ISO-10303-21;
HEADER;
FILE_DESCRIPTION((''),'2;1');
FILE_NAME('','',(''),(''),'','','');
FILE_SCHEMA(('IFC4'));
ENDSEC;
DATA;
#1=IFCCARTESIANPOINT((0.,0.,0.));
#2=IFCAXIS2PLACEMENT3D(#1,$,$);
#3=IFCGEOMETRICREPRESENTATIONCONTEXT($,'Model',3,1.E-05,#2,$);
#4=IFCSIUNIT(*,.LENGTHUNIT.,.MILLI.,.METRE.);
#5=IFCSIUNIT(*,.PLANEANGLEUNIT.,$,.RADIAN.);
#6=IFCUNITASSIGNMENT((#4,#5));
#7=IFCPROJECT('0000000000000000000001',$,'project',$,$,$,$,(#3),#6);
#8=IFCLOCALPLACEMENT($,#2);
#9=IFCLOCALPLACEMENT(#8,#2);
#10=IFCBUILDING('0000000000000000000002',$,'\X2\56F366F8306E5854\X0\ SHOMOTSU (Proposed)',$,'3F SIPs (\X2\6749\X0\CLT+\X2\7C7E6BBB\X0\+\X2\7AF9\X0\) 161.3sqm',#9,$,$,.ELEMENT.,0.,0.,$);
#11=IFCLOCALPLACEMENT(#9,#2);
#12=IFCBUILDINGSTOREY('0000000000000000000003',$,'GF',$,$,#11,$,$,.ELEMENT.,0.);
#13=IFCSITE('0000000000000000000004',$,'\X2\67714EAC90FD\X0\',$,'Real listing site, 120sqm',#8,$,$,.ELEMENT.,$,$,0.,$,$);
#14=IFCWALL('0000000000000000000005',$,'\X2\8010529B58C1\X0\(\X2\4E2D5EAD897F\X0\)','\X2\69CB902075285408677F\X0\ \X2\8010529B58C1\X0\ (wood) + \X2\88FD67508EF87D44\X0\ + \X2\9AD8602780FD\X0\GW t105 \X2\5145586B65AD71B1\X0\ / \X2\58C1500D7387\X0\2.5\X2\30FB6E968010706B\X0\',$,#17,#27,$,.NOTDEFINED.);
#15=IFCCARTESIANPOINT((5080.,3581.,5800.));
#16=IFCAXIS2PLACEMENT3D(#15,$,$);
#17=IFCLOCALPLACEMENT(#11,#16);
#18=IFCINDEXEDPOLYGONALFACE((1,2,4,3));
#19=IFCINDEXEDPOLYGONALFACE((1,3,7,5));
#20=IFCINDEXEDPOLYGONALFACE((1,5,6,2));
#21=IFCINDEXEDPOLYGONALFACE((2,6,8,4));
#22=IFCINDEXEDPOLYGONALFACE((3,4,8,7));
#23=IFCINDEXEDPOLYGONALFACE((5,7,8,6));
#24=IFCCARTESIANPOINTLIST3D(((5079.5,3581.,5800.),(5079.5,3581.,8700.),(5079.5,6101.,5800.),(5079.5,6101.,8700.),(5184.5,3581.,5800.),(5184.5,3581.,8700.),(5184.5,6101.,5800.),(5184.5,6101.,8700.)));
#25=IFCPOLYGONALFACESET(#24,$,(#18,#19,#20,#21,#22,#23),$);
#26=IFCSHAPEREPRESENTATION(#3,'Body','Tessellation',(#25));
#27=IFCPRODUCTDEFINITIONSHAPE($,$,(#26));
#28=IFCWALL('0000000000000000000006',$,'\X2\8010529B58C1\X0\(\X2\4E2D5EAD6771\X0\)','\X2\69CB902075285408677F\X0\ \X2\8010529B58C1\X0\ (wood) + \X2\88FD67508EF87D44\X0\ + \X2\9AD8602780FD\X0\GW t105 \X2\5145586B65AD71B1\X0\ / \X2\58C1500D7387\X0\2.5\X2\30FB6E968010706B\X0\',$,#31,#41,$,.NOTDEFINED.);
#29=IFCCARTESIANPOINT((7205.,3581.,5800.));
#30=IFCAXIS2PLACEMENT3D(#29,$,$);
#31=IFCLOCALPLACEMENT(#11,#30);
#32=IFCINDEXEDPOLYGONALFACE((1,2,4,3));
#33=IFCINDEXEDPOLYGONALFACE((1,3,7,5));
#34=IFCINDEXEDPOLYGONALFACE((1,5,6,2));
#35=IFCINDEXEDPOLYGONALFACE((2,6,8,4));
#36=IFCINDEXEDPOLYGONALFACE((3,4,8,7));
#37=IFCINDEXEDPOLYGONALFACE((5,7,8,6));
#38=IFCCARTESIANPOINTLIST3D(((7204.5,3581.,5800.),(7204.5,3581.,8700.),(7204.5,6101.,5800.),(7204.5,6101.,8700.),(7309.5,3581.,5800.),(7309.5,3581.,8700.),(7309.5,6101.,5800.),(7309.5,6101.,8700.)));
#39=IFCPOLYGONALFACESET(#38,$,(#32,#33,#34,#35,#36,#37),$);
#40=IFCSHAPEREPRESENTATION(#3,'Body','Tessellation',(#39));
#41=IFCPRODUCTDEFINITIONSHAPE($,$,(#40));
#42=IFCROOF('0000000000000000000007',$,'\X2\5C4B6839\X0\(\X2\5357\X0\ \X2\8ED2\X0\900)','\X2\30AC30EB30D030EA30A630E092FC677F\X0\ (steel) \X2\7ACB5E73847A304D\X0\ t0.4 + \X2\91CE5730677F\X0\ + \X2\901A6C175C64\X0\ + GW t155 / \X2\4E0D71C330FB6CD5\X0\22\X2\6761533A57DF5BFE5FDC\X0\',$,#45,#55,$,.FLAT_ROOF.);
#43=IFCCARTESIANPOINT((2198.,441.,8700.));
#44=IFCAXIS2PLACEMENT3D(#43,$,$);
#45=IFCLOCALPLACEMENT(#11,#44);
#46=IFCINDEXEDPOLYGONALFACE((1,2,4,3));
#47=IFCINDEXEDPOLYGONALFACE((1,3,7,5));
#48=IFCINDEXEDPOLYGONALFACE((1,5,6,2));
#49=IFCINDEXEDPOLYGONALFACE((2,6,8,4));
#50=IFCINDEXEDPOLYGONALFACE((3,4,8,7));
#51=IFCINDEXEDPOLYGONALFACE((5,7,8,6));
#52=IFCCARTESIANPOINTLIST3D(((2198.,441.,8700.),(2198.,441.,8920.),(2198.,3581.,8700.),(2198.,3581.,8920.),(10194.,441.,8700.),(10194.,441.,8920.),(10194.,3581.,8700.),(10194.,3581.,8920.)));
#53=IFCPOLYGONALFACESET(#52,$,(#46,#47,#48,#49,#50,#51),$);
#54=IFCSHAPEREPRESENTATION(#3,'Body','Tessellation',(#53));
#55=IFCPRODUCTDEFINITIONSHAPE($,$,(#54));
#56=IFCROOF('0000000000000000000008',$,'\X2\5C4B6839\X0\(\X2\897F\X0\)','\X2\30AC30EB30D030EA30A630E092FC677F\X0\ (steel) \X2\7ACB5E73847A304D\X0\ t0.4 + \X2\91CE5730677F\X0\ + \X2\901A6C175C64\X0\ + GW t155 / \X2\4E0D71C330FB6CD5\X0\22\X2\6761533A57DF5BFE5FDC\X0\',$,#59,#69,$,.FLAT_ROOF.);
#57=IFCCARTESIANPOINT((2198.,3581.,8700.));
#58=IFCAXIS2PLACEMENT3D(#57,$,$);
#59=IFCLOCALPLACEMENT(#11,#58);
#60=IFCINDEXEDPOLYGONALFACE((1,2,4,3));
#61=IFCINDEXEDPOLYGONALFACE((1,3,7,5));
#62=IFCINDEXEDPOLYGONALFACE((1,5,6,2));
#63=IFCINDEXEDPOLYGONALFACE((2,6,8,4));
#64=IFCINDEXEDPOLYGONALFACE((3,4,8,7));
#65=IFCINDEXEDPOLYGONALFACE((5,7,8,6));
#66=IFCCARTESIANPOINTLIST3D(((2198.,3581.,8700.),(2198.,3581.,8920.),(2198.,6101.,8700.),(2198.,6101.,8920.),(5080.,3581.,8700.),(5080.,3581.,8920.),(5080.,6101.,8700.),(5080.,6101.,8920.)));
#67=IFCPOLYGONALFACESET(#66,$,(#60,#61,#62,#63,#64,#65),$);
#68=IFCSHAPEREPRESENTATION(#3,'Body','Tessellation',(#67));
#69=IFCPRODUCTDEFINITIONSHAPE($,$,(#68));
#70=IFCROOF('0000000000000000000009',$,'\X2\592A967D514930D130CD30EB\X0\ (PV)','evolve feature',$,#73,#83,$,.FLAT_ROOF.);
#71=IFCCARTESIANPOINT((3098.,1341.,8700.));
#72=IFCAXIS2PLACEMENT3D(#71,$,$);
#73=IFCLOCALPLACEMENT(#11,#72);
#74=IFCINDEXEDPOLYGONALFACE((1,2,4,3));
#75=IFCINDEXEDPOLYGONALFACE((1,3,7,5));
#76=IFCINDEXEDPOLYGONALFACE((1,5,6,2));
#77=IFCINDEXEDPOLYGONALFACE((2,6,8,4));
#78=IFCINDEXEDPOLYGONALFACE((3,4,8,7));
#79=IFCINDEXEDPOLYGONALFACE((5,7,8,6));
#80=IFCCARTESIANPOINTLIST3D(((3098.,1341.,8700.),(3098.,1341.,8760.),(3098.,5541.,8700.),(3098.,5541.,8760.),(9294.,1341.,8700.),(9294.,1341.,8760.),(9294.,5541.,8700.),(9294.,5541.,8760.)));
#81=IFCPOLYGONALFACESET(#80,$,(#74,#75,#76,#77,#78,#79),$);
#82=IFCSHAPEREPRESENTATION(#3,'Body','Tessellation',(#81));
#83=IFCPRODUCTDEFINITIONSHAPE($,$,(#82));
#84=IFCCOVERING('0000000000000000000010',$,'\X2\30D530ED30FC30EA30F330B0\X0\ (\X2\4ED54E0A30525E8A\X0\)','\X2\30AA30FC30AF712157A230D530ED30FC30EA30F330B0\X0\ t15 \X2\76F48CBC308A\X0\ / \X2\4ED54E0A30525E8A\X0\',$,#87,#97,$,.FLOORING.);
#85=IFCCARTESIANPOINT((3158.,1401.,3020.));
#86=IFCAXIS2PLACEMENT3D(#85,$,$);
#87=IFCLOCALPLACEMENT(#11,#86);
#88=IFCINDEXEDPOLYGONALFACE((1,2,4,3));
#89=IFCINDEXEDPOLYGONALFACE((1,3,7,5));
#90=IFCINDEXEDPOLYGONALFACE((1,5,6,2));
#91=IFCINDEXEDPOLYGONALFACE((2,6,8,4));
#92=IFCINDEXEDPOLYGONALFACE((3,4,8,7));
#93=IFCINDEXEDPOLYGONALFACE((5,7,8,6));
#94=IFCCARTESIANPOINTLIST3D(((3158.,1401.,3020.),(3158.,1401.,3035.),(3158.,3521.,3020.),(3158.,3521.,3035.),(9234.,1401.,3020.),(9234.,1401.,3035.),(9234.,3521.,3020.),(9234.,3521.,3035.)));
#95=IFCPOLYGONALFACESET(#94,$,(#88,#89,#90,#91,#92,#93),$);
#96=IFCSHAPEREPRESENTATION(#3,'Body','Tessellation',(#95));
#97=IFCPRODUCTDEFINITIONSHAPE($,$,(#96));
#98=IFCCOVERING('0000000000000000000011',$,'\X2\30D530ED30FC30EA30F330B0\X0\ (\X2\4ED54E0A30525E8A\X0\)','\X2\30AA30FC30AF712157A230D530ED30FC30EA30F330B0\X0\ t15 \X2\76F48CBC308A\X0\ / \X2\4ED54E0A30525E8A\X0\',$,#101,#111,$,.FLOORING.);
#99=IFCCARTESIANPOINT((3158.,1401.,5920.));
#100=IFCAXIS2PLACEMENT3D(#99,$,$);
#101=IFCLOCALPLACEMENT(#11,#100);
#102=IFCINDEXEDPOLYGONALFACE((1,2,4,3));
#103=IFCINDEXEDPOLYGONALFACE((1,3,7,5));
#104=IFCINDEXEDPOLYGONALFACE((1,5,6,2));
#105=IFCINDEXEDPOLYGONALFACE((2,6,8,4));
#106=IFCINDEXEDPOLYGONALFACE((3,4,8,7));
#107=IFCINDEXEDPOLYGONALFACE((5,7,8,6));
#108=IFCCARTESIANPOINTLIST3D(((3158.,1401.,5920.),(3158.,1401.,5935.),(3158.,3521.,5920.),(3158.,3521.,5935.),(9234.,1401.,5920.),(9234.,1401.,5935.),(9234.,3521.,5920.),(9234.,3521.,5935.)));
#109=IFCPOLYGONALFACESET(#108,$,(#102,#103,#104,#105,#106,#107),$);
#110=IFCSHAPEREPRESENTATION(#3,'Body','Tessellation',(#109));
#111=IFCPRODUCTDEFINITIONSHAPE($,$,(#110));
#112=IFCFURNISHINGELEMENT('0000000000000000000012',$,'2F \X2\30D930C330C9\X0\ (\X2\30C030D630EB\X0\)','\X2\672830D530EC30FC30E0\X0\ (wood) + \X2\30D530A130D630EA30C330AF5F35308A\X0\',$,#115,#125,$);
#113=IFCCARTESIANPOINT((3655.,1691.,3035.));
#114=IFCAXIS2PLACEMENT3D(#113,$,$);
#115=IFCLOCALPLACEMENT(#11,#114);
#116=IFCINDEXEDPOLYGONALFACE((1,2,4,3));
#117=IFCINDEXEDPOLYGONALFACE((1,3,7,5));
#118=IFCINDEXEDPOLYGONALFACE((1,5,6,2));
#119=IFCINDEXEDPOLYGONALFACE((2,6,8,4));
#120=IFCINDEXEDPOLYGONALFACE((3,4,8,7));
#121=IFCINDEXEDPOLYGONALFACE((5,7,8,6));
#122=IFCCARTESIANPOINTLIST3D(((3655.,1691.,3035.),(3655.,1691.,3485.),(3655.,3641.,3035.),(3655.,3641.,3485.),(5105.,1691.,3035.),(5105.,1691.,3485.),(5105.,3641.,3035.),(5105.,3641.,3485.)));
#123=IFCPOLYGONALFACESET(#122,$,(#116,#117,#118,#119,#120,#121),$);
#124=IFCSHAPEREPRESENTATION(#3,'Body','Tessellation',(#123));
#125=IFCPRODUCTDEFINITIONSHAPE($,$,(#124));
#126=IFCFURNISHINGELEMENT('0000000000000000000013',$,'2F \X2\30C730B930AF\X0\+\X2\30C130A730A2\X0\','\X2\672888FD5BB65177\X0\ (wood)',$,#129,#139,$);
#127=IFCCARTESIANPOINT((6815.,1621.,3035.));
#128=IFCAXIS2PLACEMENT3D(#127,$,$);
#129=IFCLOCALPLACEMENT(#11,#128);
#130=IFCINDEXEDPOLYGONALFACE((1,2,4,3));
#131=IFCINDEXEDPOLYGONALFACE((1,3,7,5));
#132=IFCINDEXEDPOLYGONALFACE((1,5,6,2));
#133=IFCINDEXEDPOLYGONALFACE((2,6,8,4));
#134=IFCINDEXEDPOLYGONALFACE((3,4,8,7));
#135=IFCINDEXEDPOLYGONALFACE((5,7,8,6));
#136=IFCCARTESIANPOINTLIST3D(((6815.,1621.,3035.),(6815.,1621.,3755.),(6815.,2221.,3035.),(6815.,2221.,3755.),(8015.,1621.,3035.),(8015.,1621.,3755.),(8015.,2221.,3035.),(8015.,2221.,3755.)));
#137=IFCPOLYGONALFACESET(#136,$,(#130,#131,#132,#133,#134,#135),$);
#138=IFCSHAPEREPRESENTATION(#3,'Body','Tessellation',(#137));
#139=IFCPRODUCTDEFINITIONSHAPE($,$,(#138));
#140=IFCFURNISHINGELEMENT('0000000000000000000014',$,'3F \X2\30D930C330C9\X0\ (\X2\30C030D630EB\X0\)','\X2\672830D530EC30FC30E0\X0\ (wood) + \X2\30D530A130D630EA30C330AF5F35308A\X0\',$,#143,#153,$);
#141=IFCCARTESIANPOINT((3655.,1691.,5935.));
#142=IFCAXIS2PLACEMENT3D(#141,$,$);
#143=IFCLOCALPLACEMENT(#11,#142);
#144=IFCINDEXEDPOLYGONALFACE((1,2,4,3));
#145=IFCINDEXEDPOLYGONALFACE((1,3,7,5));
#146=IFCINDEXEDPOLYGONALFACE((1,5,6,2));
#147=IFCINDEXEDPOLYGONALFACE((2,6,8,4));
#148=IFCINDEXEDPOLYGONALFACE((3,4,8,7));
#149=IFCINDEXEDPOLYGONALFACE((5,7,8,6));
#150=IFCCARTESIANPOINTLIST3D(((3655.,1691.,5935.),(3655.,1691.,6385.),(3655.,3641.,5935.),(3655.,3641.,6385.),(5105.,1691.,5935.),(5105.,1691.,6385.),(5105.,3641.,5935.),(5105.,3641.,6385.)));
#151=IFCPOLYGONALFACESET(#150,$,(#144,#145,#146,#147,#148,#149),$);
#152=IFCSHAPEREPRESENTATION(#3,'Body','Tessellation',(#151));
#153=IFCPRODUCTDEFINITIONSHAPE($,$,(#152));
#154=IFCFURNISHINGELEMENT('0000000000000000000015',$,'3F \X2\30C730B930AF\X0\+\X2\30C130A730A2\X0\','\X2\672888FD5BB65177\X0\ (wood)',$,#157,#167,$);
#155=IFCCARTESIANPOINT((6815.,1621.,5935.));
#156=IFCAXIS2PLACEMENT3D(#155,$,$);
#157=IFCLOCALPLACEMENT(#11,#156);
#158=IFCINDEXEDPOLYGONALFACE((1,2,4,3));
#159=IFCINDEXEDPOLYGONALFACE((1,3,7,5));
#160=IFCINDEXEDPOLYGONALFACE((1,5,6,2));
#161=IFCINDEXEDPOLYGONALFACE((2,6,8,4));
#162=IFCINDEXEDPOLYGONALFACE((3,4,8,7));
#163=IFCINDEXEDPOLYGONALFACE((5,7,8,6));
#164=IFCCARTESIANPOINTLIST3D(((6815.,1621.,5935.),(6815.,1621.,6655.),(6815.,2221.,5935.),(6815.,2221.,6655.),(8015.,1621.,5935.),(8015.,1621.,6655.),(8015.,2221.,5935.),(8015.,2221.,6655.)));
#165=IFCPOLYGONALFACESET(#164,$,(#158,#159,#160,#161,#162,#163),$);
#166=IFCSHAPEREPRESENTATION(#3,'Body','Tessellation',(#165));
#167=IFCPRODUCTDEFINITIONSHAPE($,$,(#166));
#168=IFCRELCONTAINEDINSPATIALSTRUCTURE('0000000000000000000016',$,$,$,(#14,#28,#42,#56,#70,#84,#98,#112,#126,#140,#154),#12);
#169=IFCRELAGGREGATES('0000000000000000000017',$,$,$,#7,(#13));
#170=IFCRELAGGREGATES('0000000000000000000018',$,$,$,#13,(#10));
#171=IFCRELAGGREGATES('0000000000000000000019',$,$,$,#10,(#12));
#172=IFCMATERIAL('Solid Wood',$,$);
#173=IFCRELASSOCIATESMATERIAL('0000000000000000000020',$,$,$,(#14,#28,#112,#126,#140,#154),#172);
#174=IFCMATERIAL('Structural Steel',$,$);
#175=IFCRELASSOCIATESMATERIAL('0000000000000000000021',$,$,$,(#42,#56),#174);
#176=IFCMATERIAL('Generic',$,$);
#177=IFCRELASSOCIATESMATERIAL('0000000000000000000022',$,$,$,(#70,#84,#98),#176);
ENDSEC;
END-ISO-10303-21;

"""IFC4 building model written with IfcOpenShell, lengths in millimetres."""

from ifc_helpers import new_model, si_unit, frame, frame_2d, origin, place, context, project, spatial, rectangle, extrude, material, element, save


model = new_model("IFC4")

# Units and contexts
model_context = context("Model", 3, precision=1e-05, world=origin())
ifc_project = project(units=[si_unit("LENGTHUNIT", "METRE", prefix="MILLI"), si_unit("PLANEANGLEUNIT", "RADIAN")], contexts=[model_context])

# Site, building, storey
site_placement = place(None, origin())
site = spatial("IfcSite", under=ifc_project, at=site_placement, Name="東京都", ObjectType="Real listing site, 120sqm", CompositionType="ELEMENT", RefElevation=0.0)
building_placement = place(site_placement, origin())
building = spatial("IfcBuilding", under=site, at=building_placement, Name="図書の塔 SHOMOTSU (Proposed)", ObjectType="3F SIPs (杉CLT+籾殻+竹) 161.3sqm", CompositionType="ELEMENT", ElevationOfRefHeight=0.0, ElevationOfTerrain=0.0)
storey_placement = place(building_placement, origin())
storey = spatial("IfcBuildingStorey", under=building, at=storey_placement, Name="GF", CompositionType="ELEMENT", Elevation=0.0)

# Shared definitions
ifc_material_1 = material(Name="Solid Wood")

# Walls
wall_1_placement = place(storey_placement, frame((5080.0, 3581.0, 5800.0)))
element("IfcWall", 1, at=wall_1_placement, inside=storey, material=ifc_material_1, Name="耐力壁(中庭西)", Description="構造用合板 耐力壁 (wood) + 製材軸組 + 高性能GW t105 充填断熱 / 壁倍率2.5・準耐火", PredefinedType="NOTDEFINED", context=model_context, shape_type="SweptSolid", body=[
    extrude(rectangle(XDim=105.0, YDim=2520.0, at=frame_2d((52.0, 1260.0))), frame((5080.0, 3581.0, 5800.0)), (0.0, 0.0, 1.0), 2900.0),
])
wall_2_placement = place(storey_placement, frame((7205.0, 3581.0, 5800.0)))
element("IfcWall", 2, at=wall_2_placement, inside=storey, material=ifc_material_1, Name="耐力壁(中庭東)", Description="構造用合板 耐力壁 (wood) + 製材軸組 + 高性能GW t105 充填断熱 / 壁倍率2.5・準耐火", PredefinedType="NOTDEFINED", context=model_context, shape_type="SweptSolid", body=[
    extrude(rectangle(XDim=105.0, YDim=2520.0, at=frame_2d((52.0, 1260.0))), frame((7205.0, 3581.0, 5800.0)), (0.0, 0.0, 1.0), 2900.0),
])

# Roofs
ifc_material_2 = material(Name="Structural Steel")
roof_1_placement = place(storey_placement, frame((2198.0, 441.0, 8700.0)))
element("IfcRoof", 3, at=roof_1_placement, inside=storey, material=ifc_material_2, Name="屋根(南 軒900)", Description="ガルバリウム鋼板 (steel) 立平葺き t0.4 + 野地板 + 通気層 + GW t155 / 不燃・法22条区域対応", PredefinedType="FLAT_ROOF", context=model_context, shape_type="SweptSolid", body=[
    extrude(rectangle(XDim=7996.0, YDim=3140.0, at=frame_2d((3998.0, 1570.0))), frame((2198.0, 441.0, 8700.0)), (0.0, 0.0, 1.0), 220.0),
])
roof_2_placement = place(storey_placement, frame((2198.0, 3581.0, 8700.0)))
element("IfcRoof", 4, at=roof_2_placement, inside=storey, material=ifc_material_2, Name="屋根(西)", Description="ガルバリウム鋼板 (steel) 立平葺き t0.4 + 野地板 + 通気層 + GW t155 / 不燃・法22条区域対応", PredefinedType="FLAT_ROOF", context=model_context, shape_type="SweptSolid", body=[
    extrude(rectangle(XDim=2882.0, YDim=2520.0, at=frame_2d((1441.0, 1260.0))), frame((2198.0, 3581.0, 8700.0)), (0.0, 0.0, 1.0), 220.0),
])
ifc_material_3 = material(Name="Generic")
roof_3_placement = place(storey_placement, frame((3098.0, 1341.0, 8700.0)))
element("IfcRoof", 5, at=roof_3_placement, inside=storey, material=ifc_material_3, Name="太陽光パネル (PV)", Description="evolve feature", PredefinedType="FLAT_ROOF", context=model_context, shape_type="SweptSolid", body=[
    extrude(rectangle(XDim=6196.0, YDim=4200.0, at=frame_2d((3098.0, 2100.0))), frame((3098.0, 1341.0, 8700.0)), (0.0, 0.0, 1.0), 60.0),
])

# Coverings
covering_1_placement = place(storey_placement, frame((3158.0, 1401.0, 3020.0)))
element("IfcCovering", 6, at=covering_1_placement, inside=storey, material=ifc_material_3, Name="フローリング (仕上げ床)", Description="オーク無垢フローリング t15 直貼り / 仕上げ床", PredefinedType="FLOORING", context=model_context, shape_type="SweptSolid", body=[
    extrude(rectangle(XDim=6076.0, YDim=2120.0, at=frame_2d((3038.0, 1060.0))), frame((3158.0, 1401.0, 3020.0)), (0.0, 0.0, 1.0), 15.0),
])
covering_2_placement = place(storey_placement, frame((3158.0, 1401.0, 5920.0)))
element("IfcCovering", 7, at=covering_2_placement, inside=storey, material=ifc_material_3, Name="フローリング (仕上げ床)", Description="オーク無垢フローリング t15 直貼り / 仕上げ床", PredefinedType="FLOORING", context=model_context, shape_type="SweptSolid", body=[
    extrude(rectangle(XDim=6076.0, YDim=2120.0, at=frame_2d((3038.0, 1060.0))), frame((3158.0, 1401.0, 5920.0)), (0.0, 0.0, 1.0), 15.0),
])

# Furnishing elements
furnishing_1_placement = place(storey_placement, frame((3655.0, 1691.0, 3035.0)))
element("IfcFurnishingElement", 8, at=furnishing_1_placement, inside=storey, material=ifc_material_1, Name="2F ベッド (ダブル)", Description="木フレーム (wood) + ファブリック張り", context=model_context, shape_type="SweptSolid", body=[
    extrude(rectangle(XDim=1450.0, YDim=1950.0, at=frame_2d((725.0, 975.0))), frame((3655.0, 1691.0, 3035.0)), (0.0, 0.0, 1.0), 450.0),
])
furnishing_2_placement = place(storey_placement, frame((6815.0, 1621.0, 3035.0)))
element("IfcFurnishingElement", 9, at=furnishing_2_placement, inside=storey, material=ifc_material_1, Name="2F デスク+チェア", Description="木製家具 (wood)", context=model_context, shape_type="SweptSolid", body=[
    extrude(rectangle(XDim=1200.0, YDim=600.0, at=frame_2d((600.0, 300.0))), frame((6815.0, 1621.0, 3035.0)), (0.0, 0.0, 1.0), 720.0),
])
furnishing_3_placement = place(storey_placement, frame((3655.0, 1691.0, 5935.0)))
element("IfcFurnishingElement", 10, at=furnishing_3_placement, inside=storey, material=ifc_material_1, Name="3F ベッド (ダブル)", Description="木フレーム (wood) + ファブリック張り", context=model_context, shape_type="SweptSolid", body=[
    extrude(rectangle(XDim=1450.0, YDim=1950.0, at=frame_2d((725.0, 975.0))), frame((3655.0, 1691.0, 5935.0)), (0.0, 0.0, 1.0), 450.0),
])
furnishing_4_placement = place(storey_placement, frame((6815.0, 1621.0, 5935.0)))
element("IfcFurnishingElement", 11, at=furnishing_4_placement, inside=storey, material=ifc_material_1, Name="3F デスク+チェア", Description="木製家具 (wood)", context=model_context, shape_type="SweptSolid", body=[
    extrude(rectangle(XDim=1200.0, YDim=600.0, at=frame_2d((600.0, 300.0))), frame((6815.0, 1621.0, 5935.0)), (0.0, 0.0, 1.0), 720.0),
])

save(model, "model.ifc")
